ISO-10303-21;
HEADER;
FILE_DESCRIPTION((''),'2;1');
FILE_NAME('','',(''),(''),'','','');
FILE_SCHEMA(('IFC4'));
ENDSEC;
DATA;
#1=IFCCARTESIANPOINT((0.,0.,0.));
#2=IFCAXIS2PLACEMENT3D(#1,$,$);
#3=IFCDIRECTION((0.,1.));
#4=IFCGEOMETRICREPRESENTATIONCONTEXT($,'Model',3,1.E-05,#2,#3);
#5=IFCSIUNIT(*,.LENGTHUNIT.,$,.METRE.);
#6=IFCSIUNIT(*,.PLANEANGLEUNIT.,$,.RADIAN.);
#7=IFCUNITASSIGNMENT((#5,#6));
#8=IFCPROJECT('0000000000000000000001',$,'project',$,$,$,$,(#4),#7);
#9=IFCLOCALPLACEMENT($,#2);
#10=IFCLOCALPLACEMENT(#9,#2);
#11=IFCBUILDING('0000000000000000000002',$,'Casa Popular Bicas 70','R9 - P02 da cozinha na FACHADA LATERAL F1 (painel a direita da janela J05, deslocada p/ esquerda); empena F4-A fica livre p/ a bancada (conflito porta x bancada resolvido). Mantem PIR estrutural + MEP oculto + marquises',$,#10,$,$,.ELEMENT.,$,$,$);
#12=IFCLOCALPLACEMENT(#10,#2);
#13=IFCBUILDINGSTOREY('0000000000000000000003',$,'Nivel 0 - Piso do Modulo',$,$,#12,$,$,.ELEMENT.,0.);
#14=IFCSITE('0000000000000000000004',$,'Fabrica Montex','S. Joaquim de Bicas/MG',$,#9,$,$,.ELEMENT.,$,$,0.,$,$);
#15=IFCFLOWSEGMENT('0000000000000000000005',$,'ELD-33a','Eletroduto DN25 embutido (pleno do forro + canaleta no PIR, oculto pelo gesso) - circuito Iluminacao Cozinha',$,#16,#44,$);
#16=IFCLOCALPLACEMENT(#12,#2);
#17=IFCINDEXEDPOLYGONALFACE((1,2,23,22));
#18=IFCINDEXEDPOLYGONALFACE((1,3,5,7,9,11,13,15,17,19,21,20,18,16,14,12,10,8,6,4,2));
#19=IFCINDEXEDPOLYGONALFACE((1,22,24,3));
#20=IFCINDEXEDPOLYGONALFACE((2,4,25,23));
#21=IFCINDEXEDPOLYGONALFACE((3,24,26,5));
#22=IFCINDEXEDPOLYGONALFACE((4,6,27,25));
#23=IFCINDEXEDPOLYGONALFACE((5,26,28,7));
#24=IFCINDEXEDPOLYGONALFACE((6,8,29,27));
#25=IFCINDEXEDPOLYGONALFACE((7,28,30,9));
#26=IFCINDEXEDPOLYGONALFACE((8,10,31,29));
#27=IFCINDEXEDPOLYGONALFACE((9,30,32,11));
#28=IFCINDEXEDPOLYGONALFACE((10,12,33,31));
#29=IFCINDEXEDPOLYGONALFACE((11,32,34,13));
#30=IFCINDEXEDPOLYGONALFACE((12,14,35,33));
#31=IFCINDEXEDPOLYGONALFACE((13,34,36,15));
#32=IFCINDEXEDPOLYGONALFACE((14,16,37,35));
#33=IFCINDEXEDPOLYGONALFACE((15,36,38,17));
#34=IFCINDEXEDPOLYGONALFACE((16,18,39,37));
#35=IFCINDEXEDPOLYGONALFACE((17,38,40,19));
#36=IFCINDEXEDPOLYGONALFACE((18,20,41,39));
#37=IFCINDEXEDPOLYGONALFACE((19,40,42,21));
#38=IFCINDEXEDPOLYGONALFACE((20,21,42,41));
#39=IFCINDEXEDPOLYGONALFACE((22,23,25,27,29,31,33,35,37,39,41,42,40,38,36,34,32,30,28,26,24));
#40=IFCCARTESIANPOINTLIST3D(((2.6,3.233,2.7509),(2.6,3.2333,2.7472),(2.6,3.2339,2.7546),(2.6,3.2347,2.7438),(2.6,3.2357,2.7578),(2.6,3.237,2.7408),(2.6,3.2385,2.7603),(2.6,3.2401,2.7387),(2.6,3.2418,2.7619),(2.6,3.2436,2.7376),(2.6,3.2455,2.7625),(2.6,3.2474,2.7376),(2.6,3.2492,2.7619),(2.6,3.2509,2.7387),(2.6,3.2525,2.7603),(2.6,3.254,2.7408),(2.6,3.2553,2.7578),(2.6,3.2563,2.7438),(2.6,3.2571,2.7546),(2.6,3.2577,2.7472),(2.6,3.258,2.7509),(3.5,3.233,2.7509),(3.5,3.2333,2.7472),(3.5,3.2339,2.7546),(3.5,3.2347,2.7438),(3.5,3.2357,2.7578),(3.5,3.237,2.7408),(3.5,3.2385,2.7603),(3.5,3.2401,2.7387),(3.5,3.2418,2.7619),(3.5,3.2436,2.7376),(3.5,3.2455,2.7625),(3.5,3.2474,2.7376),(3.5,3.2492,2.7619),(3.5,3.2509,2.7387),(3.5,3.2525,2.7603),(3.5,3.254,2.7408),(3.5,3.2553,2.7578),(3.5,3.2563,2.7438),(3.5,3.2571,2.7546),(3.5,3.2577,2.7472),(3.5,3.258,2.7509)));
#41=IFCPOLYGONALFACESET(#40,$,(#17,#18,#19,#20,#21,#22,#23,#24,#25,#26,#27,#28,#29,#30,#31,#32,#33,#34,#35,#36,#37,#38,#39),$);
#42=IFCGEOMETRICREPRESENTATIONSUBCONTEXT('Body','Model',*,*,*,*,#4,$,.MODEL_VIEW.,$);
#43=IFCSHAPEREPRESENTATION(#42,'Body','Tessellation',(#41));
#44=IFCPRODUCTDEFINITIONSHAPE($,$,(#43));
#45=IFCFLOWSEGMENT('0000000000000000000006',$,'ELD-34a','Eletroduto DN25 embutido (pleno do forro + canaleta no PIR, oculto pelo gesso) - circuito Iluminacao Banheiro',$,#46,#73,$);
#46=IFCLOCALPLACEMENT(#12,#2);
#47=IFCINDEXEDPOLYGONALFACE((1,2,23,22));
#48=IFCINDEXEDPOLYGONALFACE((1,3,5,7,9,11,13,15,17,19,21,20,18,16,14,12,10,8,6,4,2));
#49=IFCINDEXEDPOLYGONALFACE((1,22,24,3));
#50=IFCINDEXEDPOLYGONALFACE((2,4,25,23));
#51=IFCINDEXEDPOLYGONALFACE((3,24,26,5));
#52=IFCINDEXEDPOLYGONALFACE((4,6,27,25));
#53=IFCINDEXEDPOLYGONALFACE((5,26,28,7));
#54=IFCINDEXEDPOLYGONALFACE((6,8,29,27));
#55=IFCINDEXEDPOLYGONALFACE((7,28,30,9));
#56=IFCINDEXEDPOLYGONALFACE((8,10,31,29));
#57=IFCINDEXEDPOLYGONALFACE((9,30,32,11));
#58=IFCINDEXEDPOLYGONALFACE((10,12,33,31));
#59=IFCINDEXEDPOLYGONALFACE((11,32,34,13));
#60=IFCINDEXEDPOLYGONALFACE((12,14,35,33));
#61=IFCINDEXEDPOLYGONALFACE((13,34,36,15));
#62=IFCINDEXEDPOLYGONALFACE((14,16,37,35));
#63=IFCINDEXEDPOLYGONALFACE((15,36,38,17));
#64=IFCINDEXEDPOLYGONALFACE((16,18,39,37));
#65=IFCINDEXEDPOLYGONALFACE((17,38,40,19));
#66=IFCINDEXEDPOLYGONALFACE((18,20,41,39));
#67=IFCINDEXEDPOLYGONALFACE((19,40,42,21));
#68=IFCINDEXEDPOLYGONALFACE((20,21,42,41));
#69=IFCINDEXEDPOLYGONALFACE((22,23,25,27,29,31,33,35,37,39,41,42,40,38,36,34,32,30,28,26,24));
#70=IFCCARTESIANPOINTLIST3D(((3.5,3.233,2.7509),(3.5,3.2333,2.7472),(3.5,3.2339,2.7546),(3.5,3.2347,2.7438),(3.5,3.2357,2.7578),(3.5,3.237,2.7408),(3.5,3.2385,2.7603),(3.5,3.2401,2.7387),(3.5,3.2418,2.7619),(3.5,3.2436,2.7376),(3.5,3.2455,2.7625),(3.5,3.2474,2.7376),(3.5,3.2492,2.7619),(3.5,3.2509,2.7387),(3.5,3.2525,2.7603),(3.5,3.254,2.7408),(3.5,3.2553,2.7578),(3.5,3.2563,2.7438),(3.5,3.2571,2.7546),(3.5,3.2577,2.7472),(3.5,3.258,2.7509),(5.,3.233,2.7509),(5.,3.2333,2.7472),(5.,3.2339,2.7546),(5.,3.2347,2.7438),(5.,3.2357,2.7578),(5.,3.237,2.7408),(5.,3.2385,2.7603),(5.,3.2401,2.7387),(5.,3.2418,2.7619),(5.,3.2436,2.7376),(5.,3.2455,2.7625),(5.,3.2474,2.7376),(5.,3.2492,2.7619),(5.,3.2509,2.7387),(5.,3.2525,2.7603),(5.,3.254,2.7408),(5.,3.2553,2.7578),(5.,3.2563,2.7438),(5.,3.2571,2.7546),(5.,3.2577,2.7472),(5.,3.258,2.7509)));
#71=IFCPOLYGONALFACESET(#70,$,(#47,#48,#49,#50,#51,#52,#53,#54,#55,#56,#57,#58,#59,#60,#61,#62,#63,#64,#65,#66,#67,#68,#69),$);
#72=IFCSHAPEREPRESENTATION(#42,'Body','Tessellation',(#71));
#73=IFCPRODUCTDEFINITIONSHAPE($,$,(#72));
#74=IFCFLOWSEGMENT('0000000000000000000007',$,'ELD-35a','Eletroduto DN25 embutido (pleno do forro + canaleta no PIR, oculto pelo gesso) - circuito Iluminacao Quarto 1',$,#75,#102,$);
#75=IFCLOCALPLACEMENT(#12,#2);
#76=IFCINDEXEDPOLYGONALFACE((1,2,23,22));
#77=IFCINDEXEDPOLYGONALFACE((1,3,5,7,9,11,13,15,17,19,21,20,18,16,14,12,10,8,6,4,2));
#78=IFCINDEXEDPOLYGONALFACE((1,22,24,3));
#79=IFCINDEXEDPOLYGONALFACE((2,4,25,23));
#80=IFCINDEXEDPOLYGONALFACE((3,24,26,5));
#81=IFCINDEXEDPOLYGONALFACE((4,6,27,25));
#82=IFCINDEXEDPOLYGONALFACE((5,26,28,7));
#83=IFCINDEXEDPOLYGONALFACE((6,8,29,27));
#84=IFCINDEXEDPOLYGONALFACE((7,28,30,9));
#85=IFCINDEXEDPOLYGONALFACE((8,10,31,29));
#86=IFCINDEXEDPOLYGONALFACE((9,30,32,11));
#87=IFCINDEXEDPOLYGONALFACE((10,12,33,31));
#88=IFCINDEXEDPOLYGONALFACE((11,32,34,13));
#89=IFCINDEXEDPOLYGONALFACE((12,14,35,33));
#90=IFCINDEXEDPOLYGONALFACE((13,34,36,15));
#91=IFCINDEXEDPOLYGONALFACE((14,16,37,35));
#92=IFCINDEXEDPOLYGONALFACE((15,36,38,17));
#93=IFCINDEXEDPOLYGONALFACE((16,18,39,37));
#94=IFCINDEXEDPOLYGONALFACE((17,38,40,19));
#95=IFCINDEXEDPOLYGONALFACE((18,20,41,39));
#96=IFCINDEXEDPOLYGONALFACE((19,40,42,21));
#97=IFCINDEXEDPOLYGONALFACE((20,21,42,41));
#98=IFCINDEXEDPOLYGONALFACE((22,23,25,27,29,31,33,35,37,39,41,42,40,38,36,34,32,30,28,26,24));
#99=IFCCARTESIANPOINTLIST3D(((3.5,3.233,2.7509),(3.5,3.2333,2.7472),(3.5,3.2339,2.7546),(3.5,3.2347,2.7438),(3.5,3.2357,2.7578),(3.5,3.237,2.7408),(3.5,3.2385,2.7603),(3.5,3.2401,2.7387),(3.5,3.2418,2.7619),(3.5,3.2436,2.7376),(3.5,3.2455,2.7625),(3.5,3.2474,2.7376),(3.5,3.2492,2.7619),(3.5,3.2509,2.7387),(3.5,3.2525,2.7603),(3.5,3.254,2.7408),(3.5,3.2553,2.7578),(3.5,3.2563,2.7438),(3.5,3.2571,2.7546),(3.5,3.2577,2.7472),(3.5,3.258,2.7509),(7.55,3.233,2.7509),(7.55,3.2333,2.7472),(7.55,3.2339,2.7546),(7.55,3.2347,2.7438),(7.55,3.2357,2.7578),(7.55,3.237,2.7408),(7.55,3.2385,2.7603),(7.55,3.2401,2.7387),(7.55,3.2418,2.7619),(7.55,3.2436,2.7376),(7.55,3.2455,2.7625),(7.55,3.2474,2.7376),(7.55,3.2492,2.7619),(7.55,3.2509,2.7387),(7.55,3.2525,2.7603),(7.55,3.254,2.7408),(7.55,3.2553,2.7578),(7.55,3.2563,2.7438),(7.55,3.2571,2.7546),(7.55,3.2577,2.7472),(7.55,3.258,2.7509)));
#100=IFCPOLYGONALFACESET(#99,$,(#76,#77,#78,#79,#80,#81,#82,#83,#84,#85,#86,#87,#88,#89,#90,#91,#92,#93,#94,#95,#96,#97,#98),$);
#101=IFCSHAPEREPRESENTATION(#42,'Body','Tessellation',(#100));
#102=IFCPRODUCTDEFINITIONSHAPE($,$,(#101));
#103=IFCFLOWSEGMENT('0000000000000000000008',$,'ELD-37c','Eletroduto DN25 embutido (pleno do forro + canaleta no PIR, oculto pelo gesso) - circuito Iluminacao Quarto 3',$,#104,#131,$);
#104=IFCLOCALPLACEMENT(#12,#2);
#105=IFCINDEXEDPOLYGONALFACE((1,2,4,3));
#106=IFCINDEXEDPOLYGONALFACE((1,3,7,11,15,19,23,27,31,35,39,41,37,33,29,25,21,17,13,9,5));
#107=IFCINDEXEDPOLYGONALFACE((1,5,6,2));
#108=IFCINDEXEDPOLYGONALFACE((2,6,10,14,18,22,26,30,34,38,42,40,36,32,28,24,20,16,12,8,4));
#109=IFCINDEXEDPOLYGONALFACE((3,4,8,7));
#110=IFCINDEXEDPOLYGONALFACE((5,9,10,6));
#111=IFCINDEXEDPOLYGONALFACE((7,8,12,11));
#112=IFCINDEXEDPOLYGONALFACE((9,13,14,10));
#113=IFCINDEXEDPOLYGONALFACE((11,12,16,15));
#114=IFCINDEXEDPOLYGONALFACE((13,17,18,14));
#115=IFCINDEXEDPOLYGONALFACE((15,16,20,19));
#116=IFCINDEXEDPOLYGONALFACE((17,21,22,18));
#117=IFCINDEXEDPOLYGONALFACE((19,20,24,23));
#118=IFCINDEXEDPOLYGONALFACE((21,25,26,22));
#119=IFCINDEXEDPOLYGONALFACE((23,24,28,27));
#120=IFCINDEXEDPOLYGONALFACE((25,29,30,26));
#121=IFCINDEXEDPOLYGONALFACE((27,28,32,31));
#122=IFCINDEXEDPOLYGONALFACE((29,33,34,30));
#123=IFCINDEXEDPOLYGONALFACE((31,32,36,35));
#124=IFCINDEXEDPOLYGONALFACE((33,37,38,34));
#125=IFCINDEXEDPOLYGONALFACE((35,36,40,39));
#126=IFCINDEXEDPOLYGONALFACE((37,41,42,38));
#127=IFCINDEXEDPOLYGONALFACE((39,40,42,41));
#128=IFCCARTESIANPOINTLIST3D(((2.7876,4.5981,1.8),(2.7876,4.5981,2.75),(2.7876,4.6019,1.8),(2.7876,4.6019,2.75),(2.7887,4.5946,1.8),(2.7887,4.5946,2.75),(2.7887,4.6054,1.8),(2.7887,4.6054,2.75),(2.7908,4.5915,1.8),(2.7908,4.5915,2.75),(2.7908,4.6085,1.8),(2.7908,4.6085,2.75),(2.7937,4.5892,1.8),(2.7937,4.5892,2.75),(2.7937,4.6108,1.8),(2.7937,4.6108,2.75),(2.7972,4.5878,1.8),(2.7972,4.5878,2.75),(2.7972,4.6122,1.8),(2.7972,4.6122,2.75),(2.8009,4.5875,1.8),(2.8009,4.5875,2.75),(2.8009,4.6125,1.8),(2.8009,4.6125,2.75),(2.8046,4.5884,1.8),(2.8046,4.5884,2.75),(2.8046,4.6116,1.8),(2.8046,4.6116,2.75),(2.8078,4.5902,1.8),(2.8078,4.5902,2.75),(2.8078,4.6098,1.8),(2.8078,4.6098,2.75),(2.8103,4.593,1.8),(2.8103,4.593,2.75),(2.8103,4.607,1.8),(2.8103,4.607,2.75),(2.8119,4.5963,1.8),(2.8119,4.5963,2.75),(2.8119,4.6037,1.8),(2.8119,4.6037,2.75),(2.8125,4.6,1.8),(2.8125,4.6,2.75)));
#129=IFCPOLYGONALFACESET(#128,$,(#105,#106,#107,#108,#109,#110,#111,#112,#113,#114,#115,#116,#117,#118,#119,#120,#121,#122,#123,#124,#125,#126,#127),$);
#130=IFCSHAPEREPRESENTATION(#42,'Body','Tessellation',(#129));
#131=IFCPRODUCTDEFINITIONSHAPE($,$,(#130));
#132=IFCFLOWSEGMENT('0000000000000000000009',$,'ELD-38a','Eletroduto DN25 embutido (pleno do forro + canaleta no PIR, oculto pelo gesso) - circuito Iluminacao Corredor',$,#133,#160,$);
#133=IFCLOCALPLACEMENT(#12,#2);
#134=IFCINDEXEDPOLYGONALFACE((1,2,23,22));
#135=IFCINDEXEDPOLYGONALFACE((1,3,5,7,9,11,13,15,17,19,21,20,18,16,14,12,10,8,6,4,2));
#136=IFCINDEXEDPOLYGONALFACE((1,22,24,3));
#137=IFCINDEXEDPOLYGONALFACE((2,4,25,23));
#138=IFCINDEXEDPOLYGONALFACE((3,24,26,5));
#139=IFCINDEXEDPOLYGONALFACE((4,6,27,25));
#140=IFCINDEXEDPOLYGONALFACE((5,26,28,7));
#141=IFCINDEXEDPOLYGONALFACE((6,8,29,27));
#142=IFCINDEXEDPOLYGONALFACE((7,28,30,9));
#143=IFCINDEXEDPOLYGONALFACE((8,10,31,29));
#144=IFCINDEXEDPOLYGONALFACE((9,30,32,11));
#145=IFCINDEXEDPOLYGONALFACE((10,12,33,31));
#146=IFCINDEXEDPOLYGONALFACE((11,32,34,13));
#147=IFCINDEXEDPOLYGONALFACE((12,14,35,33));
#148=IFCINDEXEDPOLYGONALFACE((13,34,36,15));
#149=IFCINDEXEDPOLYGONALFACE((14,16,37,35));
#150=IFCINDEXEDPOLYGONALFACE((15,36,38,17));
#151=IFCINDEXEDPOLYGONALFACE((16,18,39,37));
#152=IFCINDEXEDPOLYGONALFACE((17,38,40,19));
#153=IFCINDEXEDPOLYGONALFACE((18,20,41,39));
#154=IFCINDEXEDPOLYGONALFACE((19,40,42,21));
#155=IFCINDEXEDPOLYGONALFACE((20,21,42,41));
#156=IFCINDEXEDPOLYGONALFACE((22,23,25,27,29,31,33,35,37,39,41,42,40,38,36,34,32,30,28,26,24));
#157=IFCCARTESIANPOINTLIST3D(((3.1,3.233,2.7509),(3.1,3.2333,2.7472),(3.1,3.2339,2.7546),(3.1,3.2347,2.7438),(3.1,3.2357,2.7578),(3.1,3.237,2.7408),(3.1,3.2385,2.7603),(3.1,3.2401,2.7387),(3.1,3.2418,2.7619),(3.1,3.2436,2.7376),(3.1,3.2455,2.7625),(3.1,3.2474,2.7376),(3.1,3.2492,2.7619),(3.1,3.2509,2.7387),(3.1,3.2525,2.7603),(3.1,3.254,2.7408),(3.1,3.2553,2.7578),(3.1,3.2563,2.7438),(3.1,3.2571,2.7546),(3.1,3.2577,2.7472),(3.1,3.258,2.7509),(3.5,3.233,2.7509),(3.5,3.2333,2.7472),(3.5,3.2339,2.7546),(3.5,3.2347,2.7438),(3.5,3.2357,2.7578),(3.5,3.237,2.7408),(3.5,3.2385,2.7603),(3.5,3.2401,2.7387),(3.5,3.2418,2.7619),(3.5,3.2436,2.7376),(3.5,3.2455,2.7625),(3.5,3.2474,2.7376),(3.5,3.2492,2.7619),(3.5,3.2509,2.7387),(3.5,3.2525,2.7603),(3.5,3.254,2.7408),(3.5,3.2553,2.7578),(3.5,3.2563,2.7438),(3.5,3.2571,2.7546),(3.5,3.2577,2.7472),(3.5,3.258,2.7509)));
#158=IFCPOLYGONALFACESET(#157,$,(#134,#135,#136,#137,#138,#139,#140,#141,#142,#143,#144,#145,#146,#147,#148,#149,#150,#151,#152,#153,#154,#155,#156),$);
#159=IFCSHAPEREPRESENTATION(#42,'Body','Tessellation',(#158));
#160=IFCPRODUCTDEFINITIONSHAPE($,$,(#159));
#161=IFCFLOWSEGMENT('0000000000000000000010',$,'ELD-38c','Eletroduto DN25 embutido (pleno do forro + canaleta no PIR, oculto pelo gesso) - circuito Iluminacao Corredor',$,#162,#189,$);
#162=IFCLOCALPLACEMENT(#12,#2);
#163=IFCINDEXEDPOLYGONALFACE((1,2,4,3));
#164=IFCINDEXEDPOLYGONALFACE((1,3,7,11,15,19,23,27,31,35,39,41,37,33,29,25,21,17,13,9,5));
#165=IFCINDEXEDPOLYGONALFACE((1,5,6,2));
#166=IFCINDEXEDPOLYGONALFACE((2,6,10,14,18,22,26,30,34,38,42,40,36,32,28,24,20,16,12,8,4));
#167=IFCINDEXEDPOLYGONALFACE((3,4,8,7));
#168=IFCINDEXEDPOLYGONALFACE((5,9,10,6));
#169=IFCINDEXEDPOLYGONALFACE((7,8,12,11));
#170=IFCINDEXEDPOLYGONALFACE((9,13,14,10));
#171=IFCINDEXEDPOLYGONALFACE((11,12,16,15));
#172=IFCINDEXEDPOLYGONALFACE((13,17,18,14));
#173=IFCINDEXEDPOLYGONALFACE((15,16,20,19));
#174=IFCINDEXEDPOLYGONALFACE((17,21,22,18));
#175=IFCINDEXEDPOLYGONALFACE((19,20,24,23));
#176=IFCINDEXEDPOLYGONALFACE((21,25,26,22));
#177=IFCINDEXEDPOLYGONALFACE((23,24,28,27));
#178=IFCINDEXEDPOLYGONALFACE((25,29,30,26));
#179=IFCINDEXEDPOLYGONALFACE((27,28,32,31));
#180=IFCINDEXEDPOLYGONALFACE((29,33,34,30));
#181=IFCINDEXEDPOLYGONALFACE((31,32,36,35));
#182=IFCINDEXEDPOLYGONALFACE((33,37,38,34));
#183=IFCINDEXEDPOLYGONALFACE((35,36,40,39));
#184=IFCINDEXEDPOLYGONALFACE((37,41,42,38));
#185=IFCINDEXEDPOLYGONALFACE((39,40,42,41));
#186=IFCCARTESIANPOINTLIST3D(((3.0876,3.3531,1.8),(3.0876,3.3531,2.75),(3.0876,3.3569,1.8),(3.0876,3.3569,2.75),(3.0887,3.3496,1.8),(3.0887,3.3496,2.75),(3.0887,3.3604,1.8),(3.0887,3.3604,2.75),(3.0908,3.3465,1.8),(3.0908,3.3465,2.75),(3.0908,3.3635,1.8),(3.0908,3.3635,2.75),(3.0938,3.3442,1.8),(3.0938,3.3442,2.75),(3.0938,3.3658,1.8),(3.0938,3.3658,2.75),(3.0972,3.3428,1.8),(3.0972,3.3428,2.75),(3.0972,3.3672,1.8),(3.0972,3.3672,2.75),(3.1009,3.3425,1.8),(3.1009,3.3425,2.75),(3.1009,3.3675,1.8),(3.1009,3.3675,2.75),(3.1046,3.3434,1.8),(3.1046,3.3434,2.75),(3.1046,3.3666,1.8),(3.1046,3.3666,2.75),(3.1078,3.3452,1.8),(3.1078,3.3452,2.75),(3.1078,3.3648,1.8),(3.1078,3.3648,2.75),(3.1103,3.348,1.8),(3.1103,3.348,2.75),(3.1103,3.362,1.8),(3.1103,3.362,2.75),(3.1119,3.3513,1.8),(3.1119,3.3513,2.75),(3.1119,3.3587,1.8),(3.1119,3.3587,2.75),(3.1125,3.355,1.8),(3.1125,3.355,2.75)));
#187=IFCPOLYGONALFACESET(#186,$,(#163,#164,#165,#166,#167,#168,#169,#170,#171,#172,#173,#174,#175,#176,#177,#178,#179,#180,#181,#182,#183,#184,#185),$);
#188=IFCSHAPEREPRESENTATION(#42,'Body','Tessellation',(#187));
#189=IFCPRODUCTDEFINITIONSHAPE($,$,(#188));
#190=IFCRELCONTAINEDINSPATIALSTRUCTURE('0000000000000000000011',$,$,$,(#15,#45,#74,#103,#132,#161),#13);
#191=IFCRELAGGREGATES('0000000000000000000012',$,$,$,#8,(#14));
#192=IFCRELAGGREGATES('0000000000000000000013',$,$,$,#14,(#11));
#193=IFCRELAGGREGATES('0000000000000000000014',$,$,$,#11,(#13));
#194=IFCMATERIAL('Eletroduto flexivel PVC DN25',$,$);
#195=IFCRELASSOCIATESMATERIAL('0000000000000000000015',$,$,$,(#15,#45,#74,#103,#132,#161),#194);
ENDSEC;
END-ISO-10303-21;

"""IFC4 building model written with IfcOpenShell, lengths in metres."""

from ifc_helpers import new_model, si_unit, direction, frame, origin, origin_2d, place, context, subcontext, project, spatial, circle, extrude, material, element, save


model = new_model("IFC4")

# Units and contexts
model_context = context("Model", 3, precision=1e-05, world=origin(), true_north=direction((0.0, 1.0)))
body_context = subcontext(model_context, "Body", "Model", "MODEL_VIEW")
ifc_project = project(units=[si_unit("LENGTHUNIT", "METRE"), si_unit("PLANEANGLEUNIT", "RADIAN")], contexts=[model_context])

# Site, building, storey
site_placement = place(None, origin())
site = spatial("IfcSite", under=ifc_project, at=site_placement, Name="Fabrica Montex", Description="S. Joaquim de Bicas/MG", CompositionType="ELEMENT", RefElevation=0.0)
building_placement = place(site_placement, origin())
building = spatial("IfcBuilding", under=site, at=building_placement, Name="Casa Popular Bicas 70", Description="R9 - P02 da cozinha na FACHADA LATERAL F1 (painel a direita da janela J05, deslocada p/ esquerda); empena F4-A fica livre p/ a bancada (conflito porta x bancada resolvido). Mantem PIR estrutural + MEP oculto + marquises", CompositionType="ELEMENT")
storey_placement = place(building_placement, origin())
storey = spatial("IfcBuildingStorey", under=building, at=storey_placement, Name="Nivel 0 - Piso do Modulo", CompositionType="ELEMENT", Elevation=0.0)

# Shared definitions
ifc_material_1 = material(Name="Eletroduto flexivel PVC DN25")

# Flow segments
flow_segment_1_placement = place(storey_placement, frame((3.5, 3.2455, 2.75), z_axis=(-1.0, 0.0, 0.0), x_axis=(0.0, 0.0, 1.0)))
element("IfcFlowSegment", 1, at=flow_segment_1_placement, inside=storey, material=ifc_material_1, Name="ELD-33a", Description="Eletroduto DN25 embutido (pleno do forro + canaleta no PIR, oculto pelo gesso) - circuito Iluminacao Cozinha", context=body_context, shape_type="SweptSolid", body=[
    extrude(circle(Radius=0.0125, at=origin_2d()), origin(), (0.0, 0.0, 1.0), 0.9),
])
flow_segment_2_placement = place(storey_placement, frame((3.5, 3.2455, 2.75), z_axis=(1.0, 0.0, 0.0), x_axis=(0.0, 0.0, 1.0)))
element("IfcFlowSegment", 2, at=flow_segment_2_placement, inside=storey, material=ifc_material_1, Name="ELD-34a", Description="Eletroduto DN25 embutido (pleno do forro + canaleta no PIR, oculto pelo gesso) - circuito Iluminacao Banheiro", context=body_context, shape_type="SweptSolid", body=[
    extrude(circle(Radius=0.0125, at=origin_2d()), origin(), (0.0, 0.0, 1.0), 1.5),
])
flow_segment_3_placement = place(storey_placement, frame((3.5, 3.2455, 2.75), z_axis=(1.0, 0.0, 0.0), x_axis=(0.0, 0.0, 1.0)))
element("IfcFlowSegment", 3, at=flow_segment_3_placement, inside=storey, material=ifc_material_1, Name="ELD-35a", Description="Eletroduto DN25 embutido (pleno do forro + canaleta no PIR, oculto pelo gesso) - circuito Iluminacao Quarto 1", context=body_context, shape_type="SweptSolid", body=[
    extrude(circle(Radius=0.0125, at=origin_2d()), origin(), (0.0, 0.0, 1.0), 4.05),
])
flow_segment_4_placement = place(storey_placement, frame((2.8, 4.6, 2.75), z_axis=(0.0, 0.0, -1.0), x_axis=(1.0, 0.0, 0.0)))
element("IfcFlowSegment", 4, at=flow_segment_4_placement, inside=storey, material=ifc_material_1, Name="ELD-37c", Description="Eletroduto DN25 embutido (pleno do forro + canaleta no PIR, oculto pelo gesso) - circuito Iluminacao Quarto 3", context=body_context, shape_type="SweptSolid", body=[
    extrude(circle(Radius=0.0125, at=origin_2d()), origin(), (0.0, 0.0, 1.0), 0.95),
])
flow_segment_5_placement = place(storey_placement, frame((3.5, 3.2455, 2.75), z_axis=(-1.0, 0.0, 0.0), x_axis=(0.0, 0.0, 1.0)))
element("IfcFlowSegment", 5, at=flow_segment_5_placement, inside=storey, material=ifc_material_1, Name="ELD-38a", Description="Eletroduto DN25 embutido (pleno do forro + canaleta no PIR, oculto pelo gesso) - circuito Iluminacao Corredor", context=body_context, shape_type="SweptSolid", body=[
    extrude(circle(Radius=0.0125, at=origin_2d()), origin(), (0.0, 0.0, 1.0), 0.4),
])
flow_segment_6_placement = place(storey_placement, frame((3.1, 3.355, 2.75), z_axis=(0.0, 0.0, -1.0), x_axis=(1.0, 0.0, 0.0)))
element("IfcFlowSegment", 6, at=flow_segment_6_placement, inside=storey, material=ifc_material_1, Name="ELD-38c", Description="Eletroduto DN25 embutido (pleno do forro + canaleta no PIR, oculto pelo gesso) - circuito Iluminacao Corredor", context=body_context, shape_type="SweptSolid", body=[
    extrude(circle(Radius=0.0125, at=origin_2d()), origin(), (0.0, 0.0, 1.0), 0.95),
])

save(model, "model.ifc")
